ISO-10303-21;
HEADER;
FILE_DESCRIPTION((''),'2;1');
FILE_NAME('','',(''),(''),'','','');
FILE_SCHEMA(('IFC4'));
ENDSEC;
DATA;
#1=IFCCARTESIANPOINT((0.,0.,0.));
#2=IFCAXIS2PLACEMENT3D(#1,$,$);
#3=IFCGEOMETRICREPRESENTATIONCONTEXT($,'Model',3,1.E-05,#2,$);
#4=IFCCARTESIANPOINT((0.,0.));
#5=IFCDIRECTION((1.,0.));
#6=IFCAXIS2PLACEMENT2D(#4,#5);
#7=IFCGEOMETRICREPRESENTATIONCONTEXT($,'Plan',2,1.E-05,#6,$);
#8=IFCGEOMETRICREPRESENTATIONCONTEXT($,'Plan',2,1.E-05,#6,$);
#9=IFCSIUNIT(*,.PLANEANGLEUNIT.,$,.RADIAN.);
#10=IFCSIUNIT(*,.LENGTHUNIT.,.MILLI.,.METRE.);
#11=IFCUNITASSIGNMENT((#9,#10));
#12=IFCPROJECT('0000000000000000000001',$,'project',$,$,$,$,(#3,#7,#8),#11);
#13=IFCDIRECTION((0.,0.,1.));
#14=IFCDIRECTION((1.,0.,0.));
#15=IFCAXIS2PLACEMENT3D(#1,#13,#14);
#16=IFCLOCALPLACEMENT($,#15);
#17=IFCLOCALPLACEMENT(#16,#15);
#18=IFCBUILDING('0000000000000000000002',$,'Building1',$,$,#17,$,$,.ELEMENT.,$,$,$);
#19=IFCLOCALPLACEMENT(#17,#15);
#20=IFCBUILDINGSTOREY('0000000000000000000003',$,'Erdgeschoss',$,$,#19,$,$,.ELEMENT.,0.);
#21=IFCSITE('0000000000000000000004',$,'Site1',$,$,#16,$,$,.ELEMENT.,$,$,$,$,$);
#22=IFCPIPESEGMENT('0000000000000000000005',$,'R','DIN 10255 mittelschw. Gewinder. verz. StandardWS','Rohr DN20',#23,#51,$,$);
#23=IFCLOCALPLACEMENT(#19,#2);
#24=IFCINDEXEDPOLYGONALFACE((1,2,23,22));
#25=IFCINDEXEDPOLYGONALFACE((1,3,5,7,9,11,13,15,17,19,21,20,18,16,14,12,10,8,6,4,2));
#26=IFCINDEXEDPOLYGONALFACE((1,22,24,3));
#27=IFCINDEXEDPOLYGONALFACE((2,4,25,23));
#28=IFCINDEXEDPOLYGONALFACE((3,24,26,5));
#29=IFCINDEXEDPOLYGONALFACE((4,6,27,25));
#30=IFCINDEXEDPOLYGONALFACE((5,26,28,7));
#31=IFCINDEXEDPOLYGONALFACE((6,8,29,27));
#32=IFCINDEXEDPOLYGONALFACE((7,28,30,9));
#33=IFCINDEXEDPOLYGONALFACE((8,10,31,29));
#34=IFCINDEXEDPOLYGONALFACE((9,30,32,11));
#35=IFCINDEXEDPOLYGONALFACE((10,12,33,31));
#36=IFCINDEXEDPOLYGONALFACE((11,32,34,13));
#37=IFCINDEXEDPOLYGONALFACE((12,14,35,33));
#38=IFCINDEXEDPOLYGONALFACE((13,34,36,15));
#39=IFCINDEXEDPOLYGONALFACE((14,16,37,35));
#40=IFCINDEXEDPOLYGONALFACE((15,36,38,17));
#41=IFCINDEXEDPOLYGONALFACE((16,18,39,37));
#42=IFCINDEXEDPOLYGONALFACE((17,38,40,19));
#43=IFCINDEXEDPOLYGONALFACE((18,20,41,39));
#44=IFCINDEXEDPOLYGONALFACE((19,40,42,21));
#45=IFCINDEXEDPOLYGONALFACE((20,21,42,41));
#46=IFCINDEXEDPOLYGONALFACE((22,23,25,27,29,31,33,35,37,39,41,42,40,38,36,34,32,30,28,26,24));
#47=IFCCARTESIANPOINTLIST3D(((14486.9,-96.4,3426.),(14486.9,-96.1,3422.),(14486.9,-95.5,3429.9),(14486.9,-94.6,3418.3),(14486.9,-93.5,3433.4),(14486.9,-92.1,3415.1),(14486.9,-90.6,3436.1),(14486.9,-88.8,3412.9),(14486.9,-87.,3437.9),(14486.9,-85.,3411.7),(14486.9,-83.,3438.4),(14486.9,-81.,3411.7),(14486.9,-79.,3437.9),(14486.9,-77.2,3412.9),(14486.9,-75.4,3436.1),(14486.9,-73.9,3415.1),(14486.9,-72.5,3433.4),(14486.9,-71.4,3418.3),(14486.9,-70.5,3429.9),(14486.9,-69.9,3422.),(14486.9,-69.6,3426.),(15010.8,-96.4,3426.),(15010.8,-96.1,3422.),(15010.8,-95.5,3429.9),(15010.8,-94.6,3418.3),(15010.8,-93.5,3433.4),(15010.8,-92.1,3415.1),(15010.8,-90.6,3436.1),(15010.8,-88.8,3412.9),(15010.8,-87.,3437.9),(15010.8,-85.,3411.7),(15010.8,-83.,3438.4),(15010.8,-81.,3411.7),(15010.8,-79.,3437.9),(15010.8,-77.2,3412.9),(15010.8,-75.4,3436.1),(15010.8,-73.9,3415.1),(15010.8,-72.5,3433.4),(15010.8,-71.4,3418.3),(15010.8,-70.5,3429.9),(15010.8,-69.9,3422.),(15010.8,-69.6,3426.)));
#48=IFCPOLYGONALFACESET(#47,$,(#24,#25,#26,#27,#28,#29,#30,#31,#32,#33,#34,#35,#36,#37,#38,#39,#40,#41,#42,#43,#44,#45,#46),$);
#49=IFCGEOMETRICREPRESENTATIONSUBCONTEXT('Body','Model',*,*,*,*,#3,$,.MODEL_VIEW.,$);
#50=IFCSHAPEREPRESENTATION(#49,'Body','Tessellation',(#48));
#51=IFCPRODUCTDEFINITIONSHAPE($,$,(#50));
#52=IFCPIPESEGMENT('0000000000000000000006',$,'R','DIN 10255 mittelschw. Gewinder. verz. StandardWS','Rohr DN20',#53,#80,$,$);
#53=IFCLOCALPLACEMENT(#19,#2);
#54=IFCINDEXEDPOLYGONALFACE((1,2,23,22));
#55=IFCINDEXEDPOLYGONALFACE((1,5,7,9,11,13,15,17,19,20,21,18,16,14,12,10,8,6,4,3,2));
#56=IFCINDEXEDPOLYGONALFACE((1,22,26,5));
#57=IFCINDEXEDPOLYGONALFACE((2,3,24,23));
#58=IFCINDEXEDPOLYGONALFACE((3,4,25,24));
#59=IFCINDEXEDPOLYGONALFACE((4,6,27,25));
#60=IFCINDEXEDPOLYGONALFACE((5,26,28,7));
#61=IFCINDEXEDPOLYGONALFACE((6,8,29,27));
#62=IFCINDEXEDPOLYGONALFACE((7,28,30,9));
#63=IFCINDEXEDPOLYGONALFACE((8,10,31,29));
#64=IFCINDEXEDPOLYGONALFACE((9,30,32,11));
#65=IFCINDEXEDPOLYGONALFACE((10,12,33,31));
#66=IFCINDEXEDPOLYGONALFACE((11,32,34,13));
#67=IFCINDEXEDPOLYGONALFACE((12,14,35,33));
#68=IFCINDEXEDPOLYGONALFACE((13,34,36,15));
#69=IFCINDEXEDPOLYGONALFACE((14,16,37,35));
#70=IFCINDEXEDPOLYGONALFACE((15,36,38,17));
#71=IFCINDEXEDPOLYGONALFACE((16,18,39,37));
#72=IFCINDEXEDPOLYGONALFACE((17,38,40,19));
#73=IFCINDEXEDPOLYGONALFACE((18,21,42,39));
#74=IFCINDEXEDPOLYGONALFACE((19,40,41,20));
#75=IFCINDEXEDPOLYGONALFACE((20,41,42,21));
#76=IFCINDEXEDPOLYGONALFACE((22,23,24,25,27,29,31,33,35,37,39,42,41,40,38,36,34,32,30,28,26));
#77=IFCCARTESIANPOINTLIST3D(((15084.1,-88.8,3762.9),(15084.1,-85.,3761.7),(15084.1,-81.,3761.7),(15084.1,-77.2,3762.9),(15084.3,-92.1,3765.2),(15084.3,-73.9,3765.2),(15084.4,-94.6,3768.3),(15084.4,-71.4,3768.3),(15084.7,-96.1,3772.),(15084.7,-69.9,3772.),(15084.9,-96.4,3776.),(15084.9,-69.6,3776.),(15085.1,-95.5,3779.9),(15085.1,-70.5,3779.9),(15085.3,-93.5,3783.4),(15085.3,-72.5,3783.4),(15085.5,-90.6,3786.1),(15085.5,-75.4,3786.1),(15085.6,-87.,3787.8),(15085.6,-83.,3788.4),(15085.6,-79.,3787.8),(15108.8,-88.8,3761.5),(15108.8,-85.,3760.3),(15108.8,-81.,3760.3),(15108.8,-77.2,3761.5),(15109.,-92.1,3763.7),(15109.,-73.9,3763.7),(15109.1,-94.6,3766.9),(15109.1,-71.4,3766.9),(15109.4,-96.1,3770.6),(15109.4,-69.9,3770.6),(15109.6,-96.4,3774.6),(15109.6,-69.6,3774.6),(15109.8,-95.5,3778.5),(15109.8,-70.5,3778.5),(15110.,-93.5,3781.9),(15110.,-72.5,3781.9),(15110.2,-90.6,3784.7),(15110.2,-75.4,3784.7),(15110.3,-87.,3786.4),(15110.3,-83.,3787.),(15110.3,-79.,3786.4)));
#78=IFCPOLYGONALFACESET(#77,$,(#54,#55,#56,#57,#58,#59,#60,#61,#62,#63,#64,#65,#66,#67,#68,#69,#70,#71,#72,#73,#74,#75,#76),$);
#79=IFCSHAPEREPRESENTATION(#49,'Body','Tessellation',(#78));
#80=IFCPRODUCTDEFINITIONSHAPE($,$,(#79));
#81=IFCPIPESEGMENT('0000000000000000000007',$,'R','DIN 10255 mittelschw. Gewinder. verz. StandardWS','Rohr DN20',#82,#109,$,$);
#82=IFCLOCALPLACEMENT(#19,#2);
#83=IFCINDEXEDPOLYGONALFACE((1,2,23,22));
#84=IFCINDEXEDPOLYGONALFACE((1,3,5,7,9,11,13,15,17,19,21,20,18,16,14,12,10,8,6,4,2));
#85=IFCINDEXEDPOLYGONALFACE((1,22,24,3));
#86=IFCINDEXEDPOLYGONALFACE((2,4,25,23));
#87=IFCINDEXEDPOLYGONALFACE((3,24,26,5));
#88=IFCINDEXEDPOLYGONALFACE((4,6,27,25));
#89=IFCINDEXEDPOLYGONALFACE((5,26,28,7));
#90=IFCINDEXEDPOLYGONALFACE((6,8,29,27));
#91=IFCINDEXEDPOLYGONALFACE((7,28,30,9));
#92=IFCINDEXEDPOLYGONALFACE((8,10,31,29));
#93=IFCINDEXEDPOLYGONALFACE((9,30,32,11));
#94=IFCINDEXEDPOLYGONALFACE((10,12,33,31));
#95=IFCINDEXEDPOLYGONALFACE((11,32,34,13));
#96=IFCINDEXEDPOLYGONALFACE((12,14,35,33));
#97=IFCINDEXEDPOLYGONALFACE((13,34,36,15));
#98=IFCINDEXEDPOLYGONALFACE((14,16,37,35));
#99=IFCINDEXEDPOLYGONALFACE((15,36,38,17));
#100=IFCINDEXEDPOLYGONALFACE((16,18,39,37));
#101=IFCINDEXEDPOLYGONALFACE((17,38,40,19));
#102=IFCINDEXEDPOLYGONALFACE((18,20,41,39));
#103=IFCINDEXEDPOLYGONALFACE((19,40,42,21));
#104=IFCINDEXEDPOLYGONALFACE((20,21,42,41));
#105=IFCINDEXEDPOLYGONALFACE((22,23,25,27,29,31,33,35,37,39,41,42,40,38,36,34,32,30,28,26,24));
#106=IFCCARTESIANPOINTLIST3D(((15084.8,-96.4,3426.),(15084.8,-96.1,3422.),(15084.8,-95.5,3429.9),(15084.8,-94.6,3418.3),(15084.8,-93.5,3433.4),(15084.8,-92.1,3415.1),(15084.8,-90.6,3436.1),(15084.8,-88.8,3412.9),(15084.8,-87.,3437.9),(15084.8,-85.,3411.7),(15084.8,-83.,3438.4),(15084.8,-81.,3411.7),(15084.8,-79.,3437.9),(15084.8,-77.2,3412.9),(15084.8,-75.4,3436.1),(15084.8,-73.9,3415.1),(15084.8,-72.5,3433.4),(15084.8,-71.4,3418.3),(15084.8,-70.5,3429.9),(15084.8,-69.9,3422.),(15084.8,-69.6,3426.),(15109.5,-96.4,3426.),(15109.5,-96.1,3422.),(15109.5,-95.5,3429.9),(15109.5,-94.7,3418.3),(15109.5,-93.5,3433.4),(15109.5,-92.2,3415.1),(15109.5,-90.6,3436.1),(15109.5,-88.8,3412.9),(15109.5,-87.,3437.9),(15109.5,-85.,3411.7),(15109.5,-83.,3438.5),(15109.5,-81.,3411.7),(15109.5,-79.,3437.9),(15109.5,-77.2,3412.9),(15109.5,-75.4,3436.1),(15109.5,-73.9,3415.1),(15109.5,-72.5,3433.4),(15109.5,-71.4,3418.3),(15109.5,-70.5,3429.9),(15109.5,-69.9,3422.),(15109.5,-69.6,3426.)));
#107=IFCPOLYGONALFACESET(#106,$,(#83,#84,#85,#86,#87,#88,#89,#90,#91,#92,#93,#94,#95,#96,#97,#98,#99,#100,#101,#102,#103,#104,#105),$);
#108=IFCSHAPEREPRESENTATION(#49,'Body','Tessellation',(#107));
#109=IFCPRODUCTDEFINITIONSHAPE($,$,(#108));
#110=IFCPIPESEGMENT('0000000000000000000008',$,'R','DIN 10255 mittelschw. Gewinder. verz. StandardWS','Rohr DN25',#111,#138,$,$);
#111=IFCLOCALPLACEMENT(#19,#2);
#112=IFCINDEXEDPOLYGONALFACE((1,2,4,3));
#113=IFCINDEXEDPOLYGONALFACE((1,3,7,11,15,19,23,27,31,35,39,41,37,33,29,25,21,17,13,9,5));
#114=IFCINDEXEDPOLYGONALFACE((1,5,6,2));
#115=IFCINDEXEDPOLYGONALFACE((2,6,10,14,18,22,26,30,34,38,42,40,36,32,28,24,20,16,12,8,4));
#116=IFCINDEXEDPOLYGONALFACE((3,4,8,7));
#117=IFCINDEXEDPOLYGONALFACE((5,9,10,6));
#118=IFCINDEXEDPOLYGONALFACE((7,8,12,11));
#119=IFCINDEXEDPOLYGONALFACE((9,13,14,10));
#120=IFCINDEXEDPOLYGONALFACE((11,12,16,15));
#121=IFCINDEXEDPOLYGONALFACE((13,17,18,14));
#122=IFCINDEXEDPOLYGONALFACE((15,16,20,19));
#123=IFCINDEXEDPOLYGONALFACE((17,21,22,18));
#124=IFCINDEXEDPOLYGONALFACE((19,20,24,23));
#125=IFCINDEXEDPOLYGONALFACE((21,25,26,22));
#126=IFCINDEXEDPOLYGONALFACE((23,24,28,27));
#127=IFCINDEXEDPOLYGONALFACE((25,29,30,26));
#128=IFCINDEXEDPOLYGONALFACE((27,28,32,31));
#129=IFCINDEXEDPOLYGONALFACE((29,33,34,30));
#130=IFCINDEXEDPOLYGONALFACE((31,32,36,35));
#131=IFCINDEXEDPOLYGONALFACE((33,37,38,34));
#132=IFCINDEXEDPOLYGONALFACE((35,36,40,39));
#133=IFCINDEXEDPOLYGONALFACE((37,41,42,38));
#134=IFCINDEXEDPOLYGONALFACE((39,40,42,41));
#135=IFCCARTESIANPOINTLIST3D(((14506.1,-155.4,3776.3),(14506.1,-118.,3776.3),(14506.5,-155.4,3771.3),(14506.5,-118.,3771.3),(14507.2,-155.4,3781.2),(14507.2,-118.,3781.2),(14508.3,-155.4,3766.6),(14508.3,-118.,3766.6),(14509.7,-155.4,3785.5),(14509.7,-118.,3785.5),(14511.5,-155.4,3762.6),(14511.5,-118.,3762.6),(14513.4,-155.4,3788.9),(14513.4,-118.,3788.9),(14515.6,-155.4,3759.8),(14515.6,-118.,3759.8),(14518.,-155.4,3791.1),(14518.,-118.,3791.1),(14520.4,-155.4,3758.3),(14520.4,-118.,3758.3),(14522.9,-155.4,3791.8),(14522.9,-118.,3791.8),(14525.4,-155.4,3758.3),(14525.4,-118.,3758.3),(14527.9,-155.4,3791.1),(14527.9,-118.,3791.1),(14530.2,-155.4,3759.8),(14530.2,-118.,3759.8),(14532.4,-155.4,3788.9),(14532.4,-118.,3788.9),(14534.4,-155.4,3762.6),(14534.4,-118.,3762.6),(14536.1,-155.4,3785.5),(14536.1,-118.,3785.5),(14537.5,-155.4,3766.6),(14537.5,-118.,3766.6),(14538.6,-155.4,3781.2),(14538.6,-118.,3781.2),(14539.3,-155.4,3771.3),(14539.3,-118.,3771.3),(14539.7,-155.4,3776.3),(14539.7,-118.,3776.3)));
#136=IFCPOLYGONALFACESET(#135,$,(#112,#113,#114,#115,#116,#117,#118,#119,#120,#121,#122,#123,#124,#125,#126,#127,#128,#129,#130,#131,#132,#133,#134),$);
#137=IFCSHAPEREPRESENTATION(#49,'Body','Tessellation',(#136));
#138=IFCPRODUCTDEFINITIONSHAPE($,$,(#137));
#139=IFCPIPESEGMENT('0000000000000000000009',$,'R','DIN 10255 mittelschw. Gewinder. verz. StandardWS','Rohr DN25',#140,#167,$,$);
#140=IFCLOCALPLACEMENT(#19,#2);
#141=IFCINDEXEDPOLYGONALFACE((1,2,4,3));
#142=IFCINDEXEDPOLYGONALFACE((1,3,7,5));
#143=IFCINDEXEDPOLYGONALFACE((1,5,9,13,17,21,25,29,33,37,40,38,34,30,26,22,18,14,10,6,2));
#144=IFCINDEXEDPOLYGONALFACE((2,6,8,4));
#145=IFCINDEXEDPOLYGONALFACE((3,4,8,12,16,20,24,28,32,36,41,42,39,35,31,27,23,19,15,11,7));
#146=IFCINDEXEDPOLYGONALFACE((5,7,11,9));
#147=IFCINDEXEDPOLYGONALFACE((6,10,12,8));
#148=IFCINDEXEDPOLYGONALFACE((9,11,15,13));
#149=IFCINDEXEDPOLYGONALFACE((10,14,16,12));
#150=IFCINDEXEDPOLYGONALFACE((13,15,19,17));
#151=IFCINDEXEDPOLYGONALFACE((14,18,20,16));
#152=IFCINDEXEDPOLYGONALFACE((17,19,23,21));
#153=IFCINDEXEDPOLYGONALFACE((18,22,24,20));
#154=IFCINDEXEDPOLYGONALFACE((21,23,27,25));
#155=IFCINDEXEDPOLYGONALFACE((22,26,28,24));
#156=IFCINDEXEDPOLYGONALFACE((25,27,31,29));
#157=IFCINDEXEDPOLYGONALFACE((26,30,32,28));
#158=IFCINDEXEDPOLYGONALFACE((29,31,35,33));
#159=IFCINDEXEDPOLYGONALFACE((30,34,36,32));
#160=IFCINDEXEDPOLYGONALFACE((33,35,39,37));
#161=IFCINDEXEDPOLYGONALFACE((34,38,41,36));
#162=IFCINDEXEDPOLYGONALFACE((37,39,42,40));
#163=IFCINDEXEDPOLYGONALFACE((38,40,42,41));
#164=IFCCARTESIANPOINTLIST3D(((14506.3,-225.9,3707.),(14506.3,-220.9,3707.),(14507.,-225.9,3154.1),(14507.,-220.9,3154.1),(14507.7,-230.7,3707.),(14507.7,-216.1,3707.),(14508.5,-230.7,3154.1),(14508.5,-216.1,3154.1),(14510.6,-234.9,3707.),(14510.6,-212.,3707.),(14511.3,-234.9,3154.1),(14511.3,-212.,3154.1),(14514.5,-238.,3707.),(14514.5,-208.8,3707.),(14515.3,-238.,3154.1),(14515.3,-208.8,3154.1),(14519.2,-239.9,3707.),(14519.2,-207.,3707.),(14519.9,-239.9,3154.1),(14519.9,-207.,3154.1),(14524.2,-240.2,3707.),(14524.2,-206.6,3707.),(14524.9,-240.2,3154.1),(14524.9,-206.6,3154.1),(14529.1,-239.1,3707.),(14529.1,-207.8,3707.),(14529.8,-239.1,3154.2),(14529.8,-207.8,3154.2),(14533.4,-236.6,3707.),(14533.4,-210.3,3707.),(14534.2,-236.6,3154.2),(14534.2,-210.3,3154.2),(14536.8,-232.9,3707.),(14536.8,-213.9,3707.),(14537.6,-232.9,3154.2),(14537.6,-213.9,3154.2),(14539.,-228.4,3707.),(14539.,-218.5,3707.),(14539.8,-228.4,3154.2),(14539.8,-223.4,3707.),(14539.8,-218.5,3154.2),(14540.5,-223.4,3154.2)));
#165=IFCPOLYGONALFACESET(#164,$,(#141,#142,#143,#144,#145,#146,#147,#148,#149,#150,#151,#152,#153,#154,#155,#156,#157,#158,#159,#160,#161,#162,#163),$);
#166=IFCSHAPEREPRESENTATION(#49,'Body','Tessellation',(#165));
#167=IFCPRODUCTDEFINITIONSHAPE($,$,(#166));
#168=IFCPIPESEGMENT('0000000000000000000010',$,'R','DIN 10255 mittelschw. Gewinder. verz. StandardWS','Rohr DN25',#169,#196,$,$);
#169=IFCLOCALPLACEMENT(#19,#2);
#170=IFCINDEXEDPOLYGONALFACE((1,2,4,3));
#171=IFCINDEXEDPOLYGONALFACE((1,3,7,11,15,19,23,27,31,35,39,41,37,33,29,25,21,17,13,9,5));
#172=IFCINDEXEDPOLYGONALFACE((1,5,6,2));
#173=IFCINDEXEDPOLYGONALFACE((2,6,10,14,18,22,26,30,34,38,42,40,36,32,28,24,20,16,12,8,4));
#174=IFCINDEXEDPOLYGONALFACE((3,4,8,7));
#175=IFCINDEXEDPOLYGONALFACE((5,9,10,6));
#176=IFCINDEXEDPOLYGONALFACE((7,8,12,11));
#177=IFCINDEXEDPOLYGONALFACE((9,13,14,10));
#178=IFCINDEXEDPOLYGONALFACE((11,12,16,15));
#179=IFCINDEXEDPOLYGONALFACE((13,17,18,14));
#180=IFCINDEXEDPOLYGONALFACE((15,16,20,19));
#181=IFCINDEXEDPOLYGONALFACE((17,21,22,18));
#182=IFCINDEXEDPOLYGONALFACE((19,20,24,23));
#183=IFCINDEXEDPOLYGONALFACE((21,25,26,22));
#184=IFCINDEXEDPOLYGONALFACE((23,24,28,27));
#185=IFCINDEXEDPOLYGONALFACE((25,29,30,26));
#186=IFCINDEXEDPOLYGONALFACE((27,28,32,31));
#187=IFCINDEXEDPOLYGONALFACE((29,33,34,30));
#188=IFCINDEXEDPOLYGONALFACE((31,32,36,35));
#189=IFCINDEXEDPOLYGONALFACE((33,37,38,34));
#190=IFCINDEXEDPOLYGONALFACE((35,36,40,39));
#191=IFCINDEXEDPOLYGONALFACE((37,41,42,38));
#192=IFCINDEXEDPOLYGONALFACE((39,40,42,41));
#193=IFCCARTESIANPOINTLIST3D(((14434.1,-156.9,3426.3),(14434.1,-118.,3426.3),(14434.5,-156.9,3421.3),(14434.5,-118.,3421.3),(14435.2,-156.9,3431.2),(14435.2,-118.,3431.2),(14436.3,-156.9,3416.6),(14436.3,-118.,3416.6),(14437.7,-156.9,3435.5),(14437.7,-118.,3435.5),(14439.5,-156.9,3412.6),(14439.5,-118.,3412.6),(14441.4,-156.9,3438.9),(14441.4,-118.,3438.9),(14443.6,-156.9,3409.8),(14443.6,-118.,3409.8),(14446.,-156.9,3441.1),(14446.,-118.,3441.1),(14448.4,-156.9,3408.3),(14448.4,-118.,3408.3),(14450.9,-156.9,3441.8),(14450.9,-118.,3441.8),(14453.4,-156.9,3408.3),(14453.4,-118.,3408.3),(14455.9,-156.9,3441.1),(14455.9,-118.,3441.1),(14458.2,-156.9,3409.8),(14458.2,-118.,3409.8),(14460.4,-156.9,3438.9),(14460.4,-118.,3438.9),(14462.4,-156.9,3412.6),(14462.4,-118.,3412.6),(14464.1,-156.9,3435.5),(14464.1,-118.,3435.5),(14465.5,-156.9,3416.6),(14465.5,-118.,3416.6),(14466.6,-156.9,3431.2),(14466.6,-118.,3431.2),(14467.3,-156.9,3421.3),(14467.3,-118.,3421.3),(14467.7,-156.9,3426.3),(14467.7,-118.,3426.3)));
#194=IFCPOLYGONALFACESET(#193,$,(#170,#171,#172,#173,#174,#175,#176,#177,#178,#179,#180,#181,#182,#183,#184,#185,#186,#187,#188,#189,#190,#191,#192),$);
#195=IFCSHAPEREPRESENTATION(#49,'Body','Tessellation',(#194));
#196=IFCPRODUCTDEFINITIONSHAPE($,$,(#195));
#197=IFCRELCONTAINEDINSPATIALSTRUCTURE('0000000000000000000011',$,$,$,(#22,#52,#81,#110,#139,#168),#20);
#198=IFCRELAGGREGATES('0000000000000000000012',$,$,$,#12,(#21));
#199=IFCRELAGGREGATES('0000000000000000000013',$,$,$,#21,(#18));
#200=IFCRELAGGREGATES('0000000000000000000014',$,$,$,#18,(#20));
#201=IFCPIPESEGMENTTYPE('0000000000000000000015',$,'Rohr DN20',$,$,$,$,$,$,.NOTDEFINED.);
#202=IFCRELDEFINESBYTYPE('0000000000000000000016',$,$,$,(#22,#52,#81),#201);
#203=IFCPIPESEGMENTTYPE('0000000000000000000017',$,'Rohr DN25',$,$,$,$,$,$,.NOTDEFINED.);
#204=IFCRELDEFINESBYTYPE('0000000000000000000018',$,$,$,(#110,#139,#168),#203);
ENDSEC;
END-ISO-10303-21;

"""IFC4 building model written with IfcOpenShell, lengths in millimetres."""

from ifc_helpers import new_model, si_unit, frame, origin, origin_with_axes, origin_2d_with_axis, place, context, subcontext, project, spatial, circle, extrude, type_object, element, save


model = new_model("IFC4")

# Units and contexts
model_context = context("Model", 3, precision=1e-05, world=origin())
plan_context_1 = context("Plan", 2, precision=1e-05, world=origin_2d_with_axis())
plan_context_2 = context("Plan", 2, precision=1e-05, world=origin_2d_with_axis())
body_context = subcontext(model_context, "Body", "Model", "MODEL_VIEW")
ifc_project = project(units=[si_unit("PLANEANGLEUNIT", "RADIAN"), si_unit("LENGTHUNIT", "METRE", prefix="MILLI")], contexts=[model_context, plan_context_1, plan_context_2])

# Site, building, storey
site_placement = place(None, origin_with_axes())
site = spatial("IfcSite", under=ifc_project, at=site_placement, Name="Site1", CompositionType="ELEMENT")
building_placement = place(site_placement, origin_with_axes())
building = spatial("IfcBuilding", under=site, at=building_placement, Name="Building1", CompositionType="ELEMENT")
storey_placement = place(building_placement, origin_with_axes())
storey = spatial("IfcBuildingStorey", under=building, at=storey_placement, Name="Erdgeschoss", CompositionType="ELEMENT", Elevation=0.0)

# Pipe segments
pipe_segment_type_1 = type_object("IfcPipeSegmentType", Name="Rohr DN20", PredefinedType="NOTDEFINED")
pipe_segment_1_placement = place(storey_placement, frame((14748.9, -83.2, 3425.0), z_axis=(0.0, 0.0, 1.0), x_axis=(1.0, 0.0, 0.0)))
element("IfcPipeSegment", 1, at=pipe_segment_1_placement, inside=storey, type_object=pipe_segment_type_1, Name="R", Description="DIN 10255 mittelschw. Gewinder. verz. StandardWS", ObjectType="Rohr DN20", context=body_context, shape_type="SolidModel", body=[
    extrude(circle(Radius=13.4, at=origin_2d_with_axis()), frame((262.0, 0.2, 0.0), z_axis=(-1.0, 0.0, 0.0), x_axis=(0.0, 0.0, 1.0)), (0.0, 0.0, 1.0), 523.9),
])
pipe_segment_2_placement = place(storey_placement, frame((15097.2, -83.2, 3774.3), z_axis=(0.0, 0.0, 1.0), x_axis=(1.0, 0.0, 0.0)))
element("IfcPipeSegment", 2, at=pipe_segment_2_placement, inside=storey, type_object=pipe_segment_type_1, Name="R", Description="DIN 10255 mittelschw. Gewinder. verz. StandardWS", ObjectType="Rohr DN20", context=body_context, shape_type="SolidModel", body=[
    extrude(circle(Radius=13.4, at=origin_2d_with_axis()), frame((12.4, 0.1, -0.7), z_axis=(-0.998342, 0.0, 0.057556), x_axis=(0.0, 0.0, 1.0)), (0.0, 0.0, 1.0), 24.8),
])
pipe_segment_3_placement = place(storey_placement, frame((15097.2, -83.2, 3425.0), z_axis=(0.0, 0.0, 1.0), x_axis=(1.0, 0.0, 0.0)))
element("IfcPipeSegment", 3, at=pipe_segment_3_placement, inside=storey, type_object=pipe_segment_type_1, Name="R", Description="DIN 10255 mittelschw. Gewinder. verz. StandardWS", ObjectType="Rohr DN20", context=body_context, shape_type="SolidModel", body=[
    extrude(circle(Radius=13.4, at=origin_2d_with_axis()), frame((12.3, 0.1, 0.0), z_axis=(-1.0, 0.000133, -0.000096), x_axis=(0.0, 0.0, 1.0)), (0.0, 0.0, 1.0), 24.7),
])
pipe_segment_type_2 = type_object("IfcPipeSegmentType", Name="Rohr DN25", PredefinedType="NOTDEFINED")
pipe_segment_4_placement = place(storey_placement, frame((14523.1, -136.7, 3775.0), z_axis=(0.0, 0.0, 1.0), x_axis=(1.0, 0.0, 0.0)))
element("IfcPipeSegment", 4, at=pipe_segment_4_placement, inside=storey, type_object=pipe_segment_type_2, Name="R", Description="DIN 10255 mittelschw. Gewinder. verz. StandardWS", ObjectType="Rohr DN25", context=body_context, shape_type="SolidModel", body=[
    extrude(circle(Radius=16.9, at=origin_2d_with_axis()), frame((-0.1, 18.7, 0.0), z_axis=(0.0, -1.0, 0.0), x_axis=(0.0, 0.0, 1.0)), (0.0, 0.0, 1.0), 37.4),
])
pipe_segment_5_placement = place(storey_placement, frame((14523.3, -223.3, 3430.6), z_axis=(0.0, 0.0, 1.0), x_axis=(1.0, 0.0, 0.0)))
element("IfcPipeSegment", 5, at=pipe_segment_5_placement, inside=storey, type_object=pipe_segment_type_2, Name="R", Description="DIN 10255 mittelschw. Gewinder. verz. StandardWS", ObjectType="Rohr DN25", context=body_context, shape_type="SolidModel", body=[
    extrude(circle(Radius=16.9, at=origin_2d_with_axis()), frame((-0.4, -0.2, 276.4), z_axis=(0.001364, 0.0, -0.999999), x_axis=(1.0, 0.0, 0.0)), (0.0, 0.0, 1.0), 552.9),
])
pipe_segment_6_placement = place(storey_placement, frame((14451.1, -137.4, 3425.0), z_axis=(0.0, 0.0, 1.0), x_axis=(1.0, 0.0, 0.0)))
element("IfcPipeSegment", 6, at=pipe_segment_6_placement, inside=storey, type_object=pipe_segment_type_2, Name="R", Description="DIN 10255 mittelschw. Gewinder. verz. StandardWS", ObjectType="Rohr DN25", context=body_context, shape_type="SolidModel", body=[
    extrude(circle(Radius=16.9, at=origin_2d_with_axis()), frame((-0.1, 19.4, 0.0), z_axis=(0.0, -1.0, 0.0), x_axis=(0.0, 0.0, 1.0)), (0.0, 0.0, 1.0), 38.9),
])

save(model, "model.ifc")
